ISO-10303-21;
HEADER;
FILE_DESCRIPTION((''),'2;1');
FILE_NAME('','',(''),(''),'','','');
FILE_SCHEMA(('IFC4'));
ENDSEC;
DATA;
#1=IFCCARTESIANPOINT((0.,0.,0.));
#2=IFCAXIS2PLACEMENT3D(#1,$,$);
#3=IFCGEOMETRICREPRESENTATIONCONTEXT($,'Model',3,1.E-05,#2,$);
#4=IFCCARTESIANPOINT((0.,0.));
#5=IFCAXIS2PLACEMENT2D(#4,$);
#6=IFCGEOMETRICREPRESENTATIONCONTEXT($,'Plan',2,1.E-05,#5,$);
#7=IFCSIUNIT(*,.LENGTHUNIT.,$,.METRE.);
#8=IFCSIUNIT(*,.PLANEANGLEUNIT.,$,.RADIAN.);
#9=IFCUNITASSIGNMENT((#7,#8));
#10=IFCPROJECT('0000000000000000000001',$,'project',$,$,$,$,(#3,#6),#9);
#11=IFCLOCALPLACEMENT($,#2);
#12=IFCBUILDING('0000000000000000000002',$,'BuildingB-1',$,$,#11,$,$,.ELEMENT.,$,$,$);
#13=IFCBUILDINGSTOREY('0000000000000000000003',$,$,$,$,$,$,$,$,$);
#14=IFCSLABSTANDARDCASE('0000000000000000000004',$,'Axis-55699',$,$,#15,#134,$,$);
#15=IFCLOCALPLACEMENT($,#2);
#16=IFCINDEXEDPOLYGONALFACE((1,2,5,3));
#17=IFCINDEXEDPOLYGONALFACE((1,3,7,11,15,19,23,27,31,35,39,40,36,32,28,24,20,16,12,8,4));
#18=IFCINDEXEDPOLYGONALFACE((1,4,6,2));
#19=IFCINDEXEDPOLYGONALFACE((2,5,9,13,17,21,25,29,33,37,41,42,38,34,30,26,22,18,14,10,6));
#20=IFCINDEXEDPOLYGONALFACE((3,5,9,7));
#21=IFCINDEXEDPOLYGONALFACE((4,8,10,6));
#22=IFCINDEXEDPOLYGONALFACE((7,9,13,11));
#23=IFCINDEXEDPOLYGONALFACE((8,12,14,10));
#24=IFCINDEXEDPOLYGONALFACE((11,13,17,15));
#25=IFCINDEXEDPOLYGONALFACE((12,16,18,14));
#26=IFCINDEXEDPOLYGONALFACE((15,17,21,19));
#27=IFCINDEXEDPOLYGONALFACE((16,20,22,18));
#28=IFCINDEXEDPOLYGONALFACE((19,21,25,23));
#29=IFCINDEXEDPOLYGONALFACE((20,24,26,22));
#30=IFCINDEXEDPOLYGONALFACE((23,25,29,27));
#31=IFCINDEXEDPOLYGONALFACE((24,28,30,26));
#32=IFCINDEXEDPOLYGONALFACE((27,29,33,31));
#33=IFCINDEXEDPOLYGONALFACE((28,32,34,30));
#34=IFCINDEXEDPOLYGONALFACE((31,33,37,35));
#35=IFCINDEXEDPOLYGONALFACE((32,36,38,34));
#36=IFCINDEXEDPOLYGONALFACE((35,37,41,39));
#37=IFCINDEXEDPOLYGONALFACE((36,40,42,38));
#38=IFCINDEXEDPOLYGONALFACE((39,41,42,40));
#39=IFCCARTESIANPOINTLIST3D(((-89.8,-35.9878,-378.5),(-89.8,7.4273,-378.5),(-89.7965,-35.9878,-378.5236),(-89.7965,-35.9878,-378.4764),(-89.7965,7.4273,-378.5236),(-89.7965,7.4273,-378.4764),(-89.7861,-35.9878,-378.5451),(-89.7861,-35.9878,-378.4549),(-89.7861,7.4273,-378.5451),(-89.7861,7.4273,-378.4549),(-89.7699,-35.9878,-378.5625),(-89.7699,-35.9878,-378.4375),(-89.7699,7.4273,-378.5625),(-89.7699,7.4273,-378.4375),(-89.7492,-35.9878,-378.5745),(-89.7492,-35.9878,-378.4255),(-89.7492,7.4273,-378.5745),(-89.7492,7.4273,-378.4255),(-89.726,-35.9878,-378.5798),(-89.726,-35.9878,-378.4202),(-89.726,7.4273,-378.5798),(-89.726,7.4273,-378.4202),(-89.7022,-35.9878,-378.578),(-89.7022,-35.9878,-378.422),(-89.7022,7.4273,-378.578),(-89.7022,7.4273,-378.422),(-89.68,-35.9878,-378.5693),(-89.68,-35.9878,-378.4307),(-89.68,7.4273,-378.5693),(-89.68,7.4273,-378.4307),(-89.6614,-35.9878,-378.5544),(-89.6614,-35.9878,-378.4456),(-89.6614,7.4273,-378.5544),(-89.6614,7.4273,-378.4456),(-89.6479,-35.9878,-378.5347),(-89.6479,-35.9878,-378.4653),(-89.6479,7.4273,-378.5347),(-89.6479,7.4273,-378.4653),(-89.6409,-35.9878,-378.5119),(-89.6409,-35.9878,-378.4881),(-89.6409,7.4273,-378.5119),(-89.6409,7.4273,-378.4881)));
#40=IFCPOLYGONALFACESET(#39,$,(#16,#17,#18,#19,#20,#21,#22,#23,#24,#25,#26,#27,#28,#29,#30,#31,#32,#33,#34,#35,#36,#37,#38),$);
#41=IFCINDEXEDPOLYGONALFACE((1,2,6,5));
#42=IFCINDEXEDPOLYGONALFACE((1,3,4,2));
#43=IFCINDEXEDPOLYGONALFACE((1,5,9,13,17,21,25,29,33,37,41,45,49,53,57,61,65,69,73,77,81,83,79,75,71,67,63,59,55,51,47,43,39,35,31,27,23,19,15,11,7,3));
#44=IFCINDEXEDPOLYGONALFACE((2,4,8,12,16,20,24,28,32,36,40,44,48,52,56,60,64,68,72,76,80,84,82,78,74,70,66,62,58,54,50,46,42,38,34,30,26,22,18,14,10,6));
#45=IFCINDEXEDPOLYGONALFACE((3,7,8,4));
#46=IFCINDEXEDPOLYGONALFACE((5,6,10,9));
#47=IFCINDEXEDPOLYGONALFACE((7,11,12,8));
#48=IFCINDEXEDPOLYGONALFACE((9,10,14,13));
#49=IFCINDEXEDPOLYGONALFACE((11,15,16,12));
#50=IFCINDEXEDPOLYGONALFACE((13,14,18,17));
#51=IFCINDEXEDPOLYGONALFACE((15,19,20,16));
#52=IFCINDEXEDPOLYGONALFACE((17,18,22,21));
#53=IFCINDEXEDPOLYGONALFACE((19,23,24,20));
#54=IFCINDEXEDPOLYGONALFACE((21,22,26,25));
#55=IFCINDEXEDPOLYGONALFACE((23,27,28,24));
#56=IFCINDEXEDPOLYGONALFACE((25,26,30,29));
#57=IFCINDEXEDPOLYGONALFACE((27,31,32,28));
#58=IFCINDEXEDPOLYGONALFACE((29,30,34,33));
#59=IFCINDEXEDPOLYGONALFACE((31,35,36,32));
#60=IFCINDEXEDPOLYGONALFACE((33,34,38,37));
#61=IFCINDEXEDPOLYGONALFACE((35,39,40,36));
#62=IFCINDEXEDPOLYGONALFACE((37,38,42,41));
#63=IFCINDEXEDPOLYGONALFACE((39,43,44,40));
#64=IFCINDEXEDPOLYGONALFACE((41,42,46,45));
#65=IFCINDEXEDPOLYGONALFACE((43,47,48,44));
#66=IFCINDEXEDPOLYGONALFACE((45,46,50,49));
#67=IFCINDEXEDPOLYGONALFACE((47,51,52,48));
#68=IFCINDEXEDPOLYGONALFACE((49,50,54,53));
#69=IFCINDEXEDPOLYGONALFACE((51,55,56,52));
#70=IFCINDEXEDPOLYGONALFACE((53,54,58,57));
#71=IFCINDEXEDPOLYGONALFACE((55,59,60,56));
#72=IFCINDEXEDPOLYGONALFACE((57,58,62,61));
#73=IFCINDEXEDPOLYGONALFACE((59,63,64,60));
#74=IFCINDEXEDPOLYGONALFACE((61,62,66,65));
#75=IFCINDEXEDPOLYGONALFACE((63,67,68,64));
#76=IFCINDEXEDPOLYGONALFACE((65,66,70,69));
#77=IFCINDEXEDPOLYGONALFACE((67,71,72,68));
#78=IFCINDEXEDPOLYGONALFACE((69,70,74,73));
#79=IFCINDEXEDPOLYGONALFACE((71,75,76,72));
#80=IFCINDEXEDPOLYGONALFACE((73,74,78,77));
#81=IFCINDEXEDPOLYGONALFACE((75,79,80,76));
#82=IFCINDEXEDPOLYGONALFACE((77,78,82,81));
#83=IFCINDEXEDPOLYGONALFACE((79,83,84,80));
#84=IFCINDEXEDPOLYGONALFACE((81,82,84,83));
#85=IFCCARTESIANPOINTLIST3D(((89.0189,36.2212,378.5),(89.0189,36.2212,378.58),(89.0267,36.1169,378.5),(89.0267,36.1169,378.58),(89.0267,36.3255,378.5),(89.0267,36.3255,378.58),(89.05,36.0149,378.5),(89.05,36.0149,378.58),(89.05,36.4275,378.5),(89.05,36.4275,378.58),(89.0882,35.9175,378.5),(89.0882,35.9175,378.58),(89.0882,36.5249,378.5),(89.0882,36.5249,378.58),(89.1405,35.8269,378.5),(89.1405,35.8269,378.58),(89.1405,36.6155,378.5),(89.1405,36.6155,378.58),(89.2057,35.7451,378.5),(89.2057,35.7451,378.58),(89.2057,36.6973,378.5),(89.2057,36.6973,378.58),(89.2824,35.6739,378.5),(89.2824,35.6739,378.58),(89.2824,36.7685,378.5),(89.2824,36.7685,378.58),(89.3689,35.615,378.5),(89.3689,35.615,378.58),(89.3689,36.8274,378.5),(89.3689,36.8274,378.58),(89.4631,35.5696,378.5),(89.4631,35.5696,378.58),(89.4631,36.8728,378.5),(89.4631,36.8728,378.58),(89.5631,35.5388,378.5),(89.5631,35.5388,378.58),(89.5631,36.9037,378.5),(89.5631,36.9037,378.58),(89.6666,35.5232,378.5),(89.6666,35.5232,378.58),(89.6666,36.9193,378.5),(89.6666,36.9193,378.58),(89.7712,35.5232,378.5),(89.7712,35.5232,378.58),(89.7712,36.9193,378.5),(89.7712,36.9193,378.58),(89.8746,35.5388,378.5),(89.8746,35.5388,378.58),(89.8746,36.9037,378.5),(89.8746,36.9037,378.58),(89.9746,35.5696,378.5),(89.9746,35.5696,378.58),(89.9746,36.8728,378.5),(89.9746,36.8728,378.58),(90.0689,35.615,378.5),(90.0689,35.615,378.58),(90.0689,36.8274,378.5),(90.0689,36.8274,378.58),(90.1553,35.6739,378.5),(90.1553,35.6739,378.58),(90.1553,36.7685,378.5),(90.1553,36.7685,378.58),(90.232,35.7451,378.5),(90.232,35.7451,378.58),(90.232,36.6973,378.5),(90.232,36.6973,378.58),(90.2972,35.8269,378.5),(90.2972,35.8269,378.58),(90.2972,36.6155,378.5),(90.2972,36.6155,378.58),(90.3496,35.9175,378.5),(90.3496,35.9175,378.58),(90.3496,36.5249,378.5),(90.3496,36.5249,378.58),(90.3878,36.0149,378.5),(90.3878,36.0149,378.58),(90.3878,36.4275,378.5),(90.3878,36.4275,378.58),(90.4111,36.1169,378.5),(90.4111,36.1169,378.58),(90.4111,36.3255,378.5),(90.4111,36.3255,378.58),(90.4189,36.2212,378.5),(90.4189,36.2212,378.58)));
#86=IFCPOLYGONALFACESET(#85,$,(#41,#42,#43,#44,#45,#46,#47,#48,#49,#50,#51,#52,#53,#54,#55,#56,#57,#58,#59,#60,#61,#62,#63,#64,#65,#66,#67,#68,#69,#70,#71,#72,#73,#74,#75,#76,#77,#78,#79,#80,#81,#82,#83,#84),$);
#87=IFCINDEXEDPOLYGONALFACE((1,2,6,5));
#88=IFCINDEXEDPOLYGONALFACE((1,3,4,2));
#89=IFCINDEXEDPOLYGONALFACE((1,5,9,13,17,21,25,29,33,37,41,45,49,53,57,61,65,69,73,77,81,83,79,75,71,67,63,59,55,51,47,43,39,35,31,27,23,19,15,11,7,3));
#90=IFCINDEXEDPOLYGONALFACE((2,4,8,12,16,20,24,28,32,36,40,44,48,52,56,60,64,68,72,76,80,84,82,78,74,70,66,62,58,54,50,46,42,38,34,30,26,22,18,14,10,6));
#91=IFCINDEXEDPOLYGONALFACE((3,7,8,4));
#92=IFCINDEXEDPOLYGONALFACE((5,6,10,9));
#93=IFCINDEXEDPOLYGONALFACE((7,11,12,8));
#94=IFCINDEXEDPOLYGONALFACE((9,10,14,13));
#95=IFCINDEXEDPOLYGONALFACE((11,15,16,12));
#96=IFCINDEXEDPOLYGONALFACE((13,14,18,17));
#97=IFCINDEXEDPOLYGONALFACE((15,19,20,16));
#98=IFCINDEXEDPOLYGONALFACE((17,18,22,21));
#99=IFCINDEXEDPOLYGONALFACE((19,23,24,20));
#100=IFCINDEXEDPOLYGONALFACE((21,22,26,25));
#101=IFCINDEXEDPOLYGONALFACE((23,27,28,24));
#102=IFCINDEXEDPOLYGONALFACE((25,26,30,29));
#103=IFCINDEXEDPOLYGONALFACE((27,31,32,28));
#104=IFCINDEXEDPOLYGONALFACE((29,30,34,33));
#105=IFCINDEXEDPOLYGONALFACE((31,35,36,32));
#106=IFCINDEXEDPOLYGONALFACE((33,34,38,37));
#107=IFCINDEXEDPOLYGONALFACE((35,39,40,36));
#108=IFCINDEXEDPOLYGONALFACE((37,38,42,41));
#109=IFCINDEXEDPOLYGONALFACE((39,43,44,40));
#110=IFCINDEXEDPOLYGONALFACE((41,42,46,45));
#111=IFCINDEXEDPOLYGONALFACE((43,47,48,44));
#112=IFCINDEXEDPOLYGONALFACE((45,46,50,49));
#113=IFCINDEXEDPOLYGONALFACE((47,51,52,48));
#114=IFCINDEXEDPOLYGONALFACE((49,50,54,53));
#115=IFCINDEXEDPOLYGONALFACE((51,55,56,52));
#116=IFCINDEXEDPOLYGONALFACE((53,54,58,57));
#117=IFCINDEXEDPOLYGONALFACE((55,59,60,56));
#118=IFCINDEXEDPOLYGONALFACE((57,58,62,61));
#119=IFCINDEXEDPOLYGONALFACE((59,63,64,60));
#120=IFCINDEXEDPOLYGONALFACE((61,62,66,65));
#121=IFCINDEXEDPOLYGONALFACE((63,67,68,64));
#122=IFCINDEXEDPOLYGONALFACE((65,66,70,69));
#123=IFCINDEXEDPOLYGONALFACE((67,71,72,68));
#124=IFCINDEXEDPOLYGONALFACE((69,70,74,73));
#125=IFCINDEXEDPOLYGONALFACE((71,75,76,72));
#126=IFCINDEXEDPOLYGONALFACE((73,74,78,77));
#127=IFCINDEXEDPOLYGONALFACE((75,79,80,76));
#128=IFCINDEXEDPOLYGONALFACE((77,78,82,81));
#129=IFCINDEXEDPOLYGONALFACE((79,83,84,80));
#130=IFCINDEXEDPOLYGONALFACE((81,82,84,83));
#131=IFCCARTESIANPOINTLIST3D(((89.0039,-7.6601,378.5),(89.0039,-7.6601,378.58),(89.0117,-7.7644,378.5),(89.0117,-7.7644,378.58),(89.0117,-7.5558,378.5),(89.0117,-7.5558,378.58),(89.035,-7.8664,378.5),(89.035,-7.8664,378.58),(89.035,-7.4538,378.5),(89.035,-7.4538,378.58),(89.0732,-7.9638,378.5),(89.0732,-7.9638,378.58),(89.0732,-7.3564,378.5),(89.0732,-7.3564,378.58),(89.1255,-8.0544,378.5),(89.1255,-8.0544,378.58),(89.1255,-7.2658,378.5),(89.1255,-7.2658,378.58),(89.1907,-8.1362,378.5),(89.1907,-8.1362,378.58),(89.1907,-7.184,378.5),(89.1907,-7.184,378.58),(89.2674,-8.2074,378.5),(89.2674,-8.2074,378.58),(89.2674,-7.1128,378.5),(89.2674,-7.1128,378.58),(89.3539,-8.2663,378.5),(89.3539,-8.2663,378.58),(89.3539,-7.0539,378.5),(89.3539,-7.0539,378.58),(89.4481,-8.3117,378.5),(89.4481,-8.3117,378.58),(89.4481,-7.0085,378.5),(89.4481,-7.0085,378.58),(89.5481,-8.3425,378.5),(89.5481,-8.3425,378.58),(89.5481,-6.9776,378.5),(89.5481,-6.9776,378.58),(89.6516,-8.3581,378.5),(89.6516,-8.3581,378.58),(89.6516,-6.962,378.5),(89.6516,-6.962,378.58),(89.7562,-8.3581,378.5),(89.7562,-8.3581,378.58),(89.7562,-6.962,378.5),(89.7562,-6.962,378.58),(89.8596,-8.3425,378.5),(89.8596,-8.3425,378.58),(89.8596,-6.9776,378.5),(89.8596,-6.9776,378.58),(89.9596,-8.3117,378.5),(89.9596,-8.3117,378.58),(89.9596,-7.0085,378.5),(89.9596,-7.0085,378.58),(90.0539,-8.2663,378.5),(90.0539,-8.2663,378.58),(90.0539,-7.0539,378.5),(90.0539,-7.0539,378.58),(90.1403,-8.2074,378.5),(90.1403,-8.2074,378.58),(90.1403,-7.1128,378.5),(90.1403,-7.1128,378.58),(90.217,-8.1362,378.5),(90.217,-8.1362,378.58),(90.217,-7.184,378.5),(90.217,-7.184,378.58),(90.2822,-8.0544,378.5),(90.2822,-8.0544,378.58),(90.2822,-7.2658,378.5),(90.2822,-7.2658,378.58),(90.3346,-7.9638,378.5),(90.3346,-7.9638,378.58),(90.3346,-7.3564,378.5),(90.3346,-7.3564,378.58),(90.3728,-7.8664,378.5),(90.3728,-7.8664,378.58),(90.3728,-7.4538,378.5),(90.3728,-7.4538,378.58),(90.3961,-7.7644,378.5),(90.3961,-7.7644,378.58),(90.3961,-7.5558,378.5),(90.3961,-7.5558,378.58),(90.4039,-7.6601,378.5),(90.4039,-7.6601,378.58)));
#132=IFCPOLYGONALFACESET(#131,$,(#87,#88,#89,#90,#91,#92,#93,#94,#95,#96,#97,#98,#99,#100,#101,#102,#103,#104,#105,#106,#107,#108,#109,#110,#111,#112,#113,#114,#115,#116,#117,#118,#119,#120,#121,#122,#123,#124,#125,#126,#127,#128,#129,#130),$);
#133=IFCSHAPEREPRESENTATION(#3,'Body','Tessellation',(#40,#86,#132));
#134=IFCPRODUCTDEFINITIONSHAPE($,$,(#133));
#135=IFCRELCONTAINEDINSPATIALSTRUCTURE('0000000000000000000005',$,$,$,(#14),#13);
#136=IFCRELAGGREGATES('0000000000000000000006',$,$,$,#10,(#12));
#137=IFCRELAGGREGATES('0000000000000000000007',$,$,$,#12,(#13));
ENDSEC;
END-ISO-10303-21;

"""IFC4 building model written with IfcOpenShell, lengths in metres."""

from ifc_helpers import new_model, entity, si_unit, frame, origin, origin_2d, place, context, project, spatial, circle, extrude, element, save


model = new_model("IFC4")

# Units and contexts
model_context = context("Model", 3, precision=1e-05, world=origin())
plan_context = context("Plan", 2, precision=1e-05, world=origin_2d())
ifc_project = project(units=[si_unit("LENGTHUNIT", "METRE"), si_unit("PLANEANGLEUNIT", "RADIAN")], contexts=[model_context, plan_context])

# Building, storey
building_placement = place(None, origin())
building = spatial("IfcBuilding", under=ifc_project, at=building_placement, Name="BuildingB-1", CompositionType="ELEMENT")
storey = spatial("IfcBuildingStorey", under=building)

# Slab
element("IfcSlabStandardCase", 1, inside=storey, Name="Axis-55699", context=model_context, shape_type="AdvancedSweptSolid", body=[
    entity("IfcSurfaceCurveSweptAreaSolid", entity("IfcCircleProfileDef", "AREA", None, None, 0.08), None, entity("IfcPolyline", [entity("IfcCartesianPoint", [89.72, 35.9878, 378.5]), entity("IfcCartesianPoint", [89.72, -7.4273, 378.5])]), None, None, entity("IfcPlane", entity("IfcAxis2Placement3D", entity("IfcCartesianPoint", [89.72, 35.9878, 378.5]), entity("IfcDirection", [0.0, 0.0, 1.0]), entity("IfcDirection", [1.0, 0.0, 0.0])))),
    extrude(circle(Radius=0.7), frame((89.7189, 36.2212, 378.5)), (0.0, 0.0, 1.0), 0.08),
    extrude(circle(Radius=0.7), frame((89.7039, -7.6601, 378.5)), (0.0, 0.0, 1.0), 0.08),
])

save(model, "model.ifc")
